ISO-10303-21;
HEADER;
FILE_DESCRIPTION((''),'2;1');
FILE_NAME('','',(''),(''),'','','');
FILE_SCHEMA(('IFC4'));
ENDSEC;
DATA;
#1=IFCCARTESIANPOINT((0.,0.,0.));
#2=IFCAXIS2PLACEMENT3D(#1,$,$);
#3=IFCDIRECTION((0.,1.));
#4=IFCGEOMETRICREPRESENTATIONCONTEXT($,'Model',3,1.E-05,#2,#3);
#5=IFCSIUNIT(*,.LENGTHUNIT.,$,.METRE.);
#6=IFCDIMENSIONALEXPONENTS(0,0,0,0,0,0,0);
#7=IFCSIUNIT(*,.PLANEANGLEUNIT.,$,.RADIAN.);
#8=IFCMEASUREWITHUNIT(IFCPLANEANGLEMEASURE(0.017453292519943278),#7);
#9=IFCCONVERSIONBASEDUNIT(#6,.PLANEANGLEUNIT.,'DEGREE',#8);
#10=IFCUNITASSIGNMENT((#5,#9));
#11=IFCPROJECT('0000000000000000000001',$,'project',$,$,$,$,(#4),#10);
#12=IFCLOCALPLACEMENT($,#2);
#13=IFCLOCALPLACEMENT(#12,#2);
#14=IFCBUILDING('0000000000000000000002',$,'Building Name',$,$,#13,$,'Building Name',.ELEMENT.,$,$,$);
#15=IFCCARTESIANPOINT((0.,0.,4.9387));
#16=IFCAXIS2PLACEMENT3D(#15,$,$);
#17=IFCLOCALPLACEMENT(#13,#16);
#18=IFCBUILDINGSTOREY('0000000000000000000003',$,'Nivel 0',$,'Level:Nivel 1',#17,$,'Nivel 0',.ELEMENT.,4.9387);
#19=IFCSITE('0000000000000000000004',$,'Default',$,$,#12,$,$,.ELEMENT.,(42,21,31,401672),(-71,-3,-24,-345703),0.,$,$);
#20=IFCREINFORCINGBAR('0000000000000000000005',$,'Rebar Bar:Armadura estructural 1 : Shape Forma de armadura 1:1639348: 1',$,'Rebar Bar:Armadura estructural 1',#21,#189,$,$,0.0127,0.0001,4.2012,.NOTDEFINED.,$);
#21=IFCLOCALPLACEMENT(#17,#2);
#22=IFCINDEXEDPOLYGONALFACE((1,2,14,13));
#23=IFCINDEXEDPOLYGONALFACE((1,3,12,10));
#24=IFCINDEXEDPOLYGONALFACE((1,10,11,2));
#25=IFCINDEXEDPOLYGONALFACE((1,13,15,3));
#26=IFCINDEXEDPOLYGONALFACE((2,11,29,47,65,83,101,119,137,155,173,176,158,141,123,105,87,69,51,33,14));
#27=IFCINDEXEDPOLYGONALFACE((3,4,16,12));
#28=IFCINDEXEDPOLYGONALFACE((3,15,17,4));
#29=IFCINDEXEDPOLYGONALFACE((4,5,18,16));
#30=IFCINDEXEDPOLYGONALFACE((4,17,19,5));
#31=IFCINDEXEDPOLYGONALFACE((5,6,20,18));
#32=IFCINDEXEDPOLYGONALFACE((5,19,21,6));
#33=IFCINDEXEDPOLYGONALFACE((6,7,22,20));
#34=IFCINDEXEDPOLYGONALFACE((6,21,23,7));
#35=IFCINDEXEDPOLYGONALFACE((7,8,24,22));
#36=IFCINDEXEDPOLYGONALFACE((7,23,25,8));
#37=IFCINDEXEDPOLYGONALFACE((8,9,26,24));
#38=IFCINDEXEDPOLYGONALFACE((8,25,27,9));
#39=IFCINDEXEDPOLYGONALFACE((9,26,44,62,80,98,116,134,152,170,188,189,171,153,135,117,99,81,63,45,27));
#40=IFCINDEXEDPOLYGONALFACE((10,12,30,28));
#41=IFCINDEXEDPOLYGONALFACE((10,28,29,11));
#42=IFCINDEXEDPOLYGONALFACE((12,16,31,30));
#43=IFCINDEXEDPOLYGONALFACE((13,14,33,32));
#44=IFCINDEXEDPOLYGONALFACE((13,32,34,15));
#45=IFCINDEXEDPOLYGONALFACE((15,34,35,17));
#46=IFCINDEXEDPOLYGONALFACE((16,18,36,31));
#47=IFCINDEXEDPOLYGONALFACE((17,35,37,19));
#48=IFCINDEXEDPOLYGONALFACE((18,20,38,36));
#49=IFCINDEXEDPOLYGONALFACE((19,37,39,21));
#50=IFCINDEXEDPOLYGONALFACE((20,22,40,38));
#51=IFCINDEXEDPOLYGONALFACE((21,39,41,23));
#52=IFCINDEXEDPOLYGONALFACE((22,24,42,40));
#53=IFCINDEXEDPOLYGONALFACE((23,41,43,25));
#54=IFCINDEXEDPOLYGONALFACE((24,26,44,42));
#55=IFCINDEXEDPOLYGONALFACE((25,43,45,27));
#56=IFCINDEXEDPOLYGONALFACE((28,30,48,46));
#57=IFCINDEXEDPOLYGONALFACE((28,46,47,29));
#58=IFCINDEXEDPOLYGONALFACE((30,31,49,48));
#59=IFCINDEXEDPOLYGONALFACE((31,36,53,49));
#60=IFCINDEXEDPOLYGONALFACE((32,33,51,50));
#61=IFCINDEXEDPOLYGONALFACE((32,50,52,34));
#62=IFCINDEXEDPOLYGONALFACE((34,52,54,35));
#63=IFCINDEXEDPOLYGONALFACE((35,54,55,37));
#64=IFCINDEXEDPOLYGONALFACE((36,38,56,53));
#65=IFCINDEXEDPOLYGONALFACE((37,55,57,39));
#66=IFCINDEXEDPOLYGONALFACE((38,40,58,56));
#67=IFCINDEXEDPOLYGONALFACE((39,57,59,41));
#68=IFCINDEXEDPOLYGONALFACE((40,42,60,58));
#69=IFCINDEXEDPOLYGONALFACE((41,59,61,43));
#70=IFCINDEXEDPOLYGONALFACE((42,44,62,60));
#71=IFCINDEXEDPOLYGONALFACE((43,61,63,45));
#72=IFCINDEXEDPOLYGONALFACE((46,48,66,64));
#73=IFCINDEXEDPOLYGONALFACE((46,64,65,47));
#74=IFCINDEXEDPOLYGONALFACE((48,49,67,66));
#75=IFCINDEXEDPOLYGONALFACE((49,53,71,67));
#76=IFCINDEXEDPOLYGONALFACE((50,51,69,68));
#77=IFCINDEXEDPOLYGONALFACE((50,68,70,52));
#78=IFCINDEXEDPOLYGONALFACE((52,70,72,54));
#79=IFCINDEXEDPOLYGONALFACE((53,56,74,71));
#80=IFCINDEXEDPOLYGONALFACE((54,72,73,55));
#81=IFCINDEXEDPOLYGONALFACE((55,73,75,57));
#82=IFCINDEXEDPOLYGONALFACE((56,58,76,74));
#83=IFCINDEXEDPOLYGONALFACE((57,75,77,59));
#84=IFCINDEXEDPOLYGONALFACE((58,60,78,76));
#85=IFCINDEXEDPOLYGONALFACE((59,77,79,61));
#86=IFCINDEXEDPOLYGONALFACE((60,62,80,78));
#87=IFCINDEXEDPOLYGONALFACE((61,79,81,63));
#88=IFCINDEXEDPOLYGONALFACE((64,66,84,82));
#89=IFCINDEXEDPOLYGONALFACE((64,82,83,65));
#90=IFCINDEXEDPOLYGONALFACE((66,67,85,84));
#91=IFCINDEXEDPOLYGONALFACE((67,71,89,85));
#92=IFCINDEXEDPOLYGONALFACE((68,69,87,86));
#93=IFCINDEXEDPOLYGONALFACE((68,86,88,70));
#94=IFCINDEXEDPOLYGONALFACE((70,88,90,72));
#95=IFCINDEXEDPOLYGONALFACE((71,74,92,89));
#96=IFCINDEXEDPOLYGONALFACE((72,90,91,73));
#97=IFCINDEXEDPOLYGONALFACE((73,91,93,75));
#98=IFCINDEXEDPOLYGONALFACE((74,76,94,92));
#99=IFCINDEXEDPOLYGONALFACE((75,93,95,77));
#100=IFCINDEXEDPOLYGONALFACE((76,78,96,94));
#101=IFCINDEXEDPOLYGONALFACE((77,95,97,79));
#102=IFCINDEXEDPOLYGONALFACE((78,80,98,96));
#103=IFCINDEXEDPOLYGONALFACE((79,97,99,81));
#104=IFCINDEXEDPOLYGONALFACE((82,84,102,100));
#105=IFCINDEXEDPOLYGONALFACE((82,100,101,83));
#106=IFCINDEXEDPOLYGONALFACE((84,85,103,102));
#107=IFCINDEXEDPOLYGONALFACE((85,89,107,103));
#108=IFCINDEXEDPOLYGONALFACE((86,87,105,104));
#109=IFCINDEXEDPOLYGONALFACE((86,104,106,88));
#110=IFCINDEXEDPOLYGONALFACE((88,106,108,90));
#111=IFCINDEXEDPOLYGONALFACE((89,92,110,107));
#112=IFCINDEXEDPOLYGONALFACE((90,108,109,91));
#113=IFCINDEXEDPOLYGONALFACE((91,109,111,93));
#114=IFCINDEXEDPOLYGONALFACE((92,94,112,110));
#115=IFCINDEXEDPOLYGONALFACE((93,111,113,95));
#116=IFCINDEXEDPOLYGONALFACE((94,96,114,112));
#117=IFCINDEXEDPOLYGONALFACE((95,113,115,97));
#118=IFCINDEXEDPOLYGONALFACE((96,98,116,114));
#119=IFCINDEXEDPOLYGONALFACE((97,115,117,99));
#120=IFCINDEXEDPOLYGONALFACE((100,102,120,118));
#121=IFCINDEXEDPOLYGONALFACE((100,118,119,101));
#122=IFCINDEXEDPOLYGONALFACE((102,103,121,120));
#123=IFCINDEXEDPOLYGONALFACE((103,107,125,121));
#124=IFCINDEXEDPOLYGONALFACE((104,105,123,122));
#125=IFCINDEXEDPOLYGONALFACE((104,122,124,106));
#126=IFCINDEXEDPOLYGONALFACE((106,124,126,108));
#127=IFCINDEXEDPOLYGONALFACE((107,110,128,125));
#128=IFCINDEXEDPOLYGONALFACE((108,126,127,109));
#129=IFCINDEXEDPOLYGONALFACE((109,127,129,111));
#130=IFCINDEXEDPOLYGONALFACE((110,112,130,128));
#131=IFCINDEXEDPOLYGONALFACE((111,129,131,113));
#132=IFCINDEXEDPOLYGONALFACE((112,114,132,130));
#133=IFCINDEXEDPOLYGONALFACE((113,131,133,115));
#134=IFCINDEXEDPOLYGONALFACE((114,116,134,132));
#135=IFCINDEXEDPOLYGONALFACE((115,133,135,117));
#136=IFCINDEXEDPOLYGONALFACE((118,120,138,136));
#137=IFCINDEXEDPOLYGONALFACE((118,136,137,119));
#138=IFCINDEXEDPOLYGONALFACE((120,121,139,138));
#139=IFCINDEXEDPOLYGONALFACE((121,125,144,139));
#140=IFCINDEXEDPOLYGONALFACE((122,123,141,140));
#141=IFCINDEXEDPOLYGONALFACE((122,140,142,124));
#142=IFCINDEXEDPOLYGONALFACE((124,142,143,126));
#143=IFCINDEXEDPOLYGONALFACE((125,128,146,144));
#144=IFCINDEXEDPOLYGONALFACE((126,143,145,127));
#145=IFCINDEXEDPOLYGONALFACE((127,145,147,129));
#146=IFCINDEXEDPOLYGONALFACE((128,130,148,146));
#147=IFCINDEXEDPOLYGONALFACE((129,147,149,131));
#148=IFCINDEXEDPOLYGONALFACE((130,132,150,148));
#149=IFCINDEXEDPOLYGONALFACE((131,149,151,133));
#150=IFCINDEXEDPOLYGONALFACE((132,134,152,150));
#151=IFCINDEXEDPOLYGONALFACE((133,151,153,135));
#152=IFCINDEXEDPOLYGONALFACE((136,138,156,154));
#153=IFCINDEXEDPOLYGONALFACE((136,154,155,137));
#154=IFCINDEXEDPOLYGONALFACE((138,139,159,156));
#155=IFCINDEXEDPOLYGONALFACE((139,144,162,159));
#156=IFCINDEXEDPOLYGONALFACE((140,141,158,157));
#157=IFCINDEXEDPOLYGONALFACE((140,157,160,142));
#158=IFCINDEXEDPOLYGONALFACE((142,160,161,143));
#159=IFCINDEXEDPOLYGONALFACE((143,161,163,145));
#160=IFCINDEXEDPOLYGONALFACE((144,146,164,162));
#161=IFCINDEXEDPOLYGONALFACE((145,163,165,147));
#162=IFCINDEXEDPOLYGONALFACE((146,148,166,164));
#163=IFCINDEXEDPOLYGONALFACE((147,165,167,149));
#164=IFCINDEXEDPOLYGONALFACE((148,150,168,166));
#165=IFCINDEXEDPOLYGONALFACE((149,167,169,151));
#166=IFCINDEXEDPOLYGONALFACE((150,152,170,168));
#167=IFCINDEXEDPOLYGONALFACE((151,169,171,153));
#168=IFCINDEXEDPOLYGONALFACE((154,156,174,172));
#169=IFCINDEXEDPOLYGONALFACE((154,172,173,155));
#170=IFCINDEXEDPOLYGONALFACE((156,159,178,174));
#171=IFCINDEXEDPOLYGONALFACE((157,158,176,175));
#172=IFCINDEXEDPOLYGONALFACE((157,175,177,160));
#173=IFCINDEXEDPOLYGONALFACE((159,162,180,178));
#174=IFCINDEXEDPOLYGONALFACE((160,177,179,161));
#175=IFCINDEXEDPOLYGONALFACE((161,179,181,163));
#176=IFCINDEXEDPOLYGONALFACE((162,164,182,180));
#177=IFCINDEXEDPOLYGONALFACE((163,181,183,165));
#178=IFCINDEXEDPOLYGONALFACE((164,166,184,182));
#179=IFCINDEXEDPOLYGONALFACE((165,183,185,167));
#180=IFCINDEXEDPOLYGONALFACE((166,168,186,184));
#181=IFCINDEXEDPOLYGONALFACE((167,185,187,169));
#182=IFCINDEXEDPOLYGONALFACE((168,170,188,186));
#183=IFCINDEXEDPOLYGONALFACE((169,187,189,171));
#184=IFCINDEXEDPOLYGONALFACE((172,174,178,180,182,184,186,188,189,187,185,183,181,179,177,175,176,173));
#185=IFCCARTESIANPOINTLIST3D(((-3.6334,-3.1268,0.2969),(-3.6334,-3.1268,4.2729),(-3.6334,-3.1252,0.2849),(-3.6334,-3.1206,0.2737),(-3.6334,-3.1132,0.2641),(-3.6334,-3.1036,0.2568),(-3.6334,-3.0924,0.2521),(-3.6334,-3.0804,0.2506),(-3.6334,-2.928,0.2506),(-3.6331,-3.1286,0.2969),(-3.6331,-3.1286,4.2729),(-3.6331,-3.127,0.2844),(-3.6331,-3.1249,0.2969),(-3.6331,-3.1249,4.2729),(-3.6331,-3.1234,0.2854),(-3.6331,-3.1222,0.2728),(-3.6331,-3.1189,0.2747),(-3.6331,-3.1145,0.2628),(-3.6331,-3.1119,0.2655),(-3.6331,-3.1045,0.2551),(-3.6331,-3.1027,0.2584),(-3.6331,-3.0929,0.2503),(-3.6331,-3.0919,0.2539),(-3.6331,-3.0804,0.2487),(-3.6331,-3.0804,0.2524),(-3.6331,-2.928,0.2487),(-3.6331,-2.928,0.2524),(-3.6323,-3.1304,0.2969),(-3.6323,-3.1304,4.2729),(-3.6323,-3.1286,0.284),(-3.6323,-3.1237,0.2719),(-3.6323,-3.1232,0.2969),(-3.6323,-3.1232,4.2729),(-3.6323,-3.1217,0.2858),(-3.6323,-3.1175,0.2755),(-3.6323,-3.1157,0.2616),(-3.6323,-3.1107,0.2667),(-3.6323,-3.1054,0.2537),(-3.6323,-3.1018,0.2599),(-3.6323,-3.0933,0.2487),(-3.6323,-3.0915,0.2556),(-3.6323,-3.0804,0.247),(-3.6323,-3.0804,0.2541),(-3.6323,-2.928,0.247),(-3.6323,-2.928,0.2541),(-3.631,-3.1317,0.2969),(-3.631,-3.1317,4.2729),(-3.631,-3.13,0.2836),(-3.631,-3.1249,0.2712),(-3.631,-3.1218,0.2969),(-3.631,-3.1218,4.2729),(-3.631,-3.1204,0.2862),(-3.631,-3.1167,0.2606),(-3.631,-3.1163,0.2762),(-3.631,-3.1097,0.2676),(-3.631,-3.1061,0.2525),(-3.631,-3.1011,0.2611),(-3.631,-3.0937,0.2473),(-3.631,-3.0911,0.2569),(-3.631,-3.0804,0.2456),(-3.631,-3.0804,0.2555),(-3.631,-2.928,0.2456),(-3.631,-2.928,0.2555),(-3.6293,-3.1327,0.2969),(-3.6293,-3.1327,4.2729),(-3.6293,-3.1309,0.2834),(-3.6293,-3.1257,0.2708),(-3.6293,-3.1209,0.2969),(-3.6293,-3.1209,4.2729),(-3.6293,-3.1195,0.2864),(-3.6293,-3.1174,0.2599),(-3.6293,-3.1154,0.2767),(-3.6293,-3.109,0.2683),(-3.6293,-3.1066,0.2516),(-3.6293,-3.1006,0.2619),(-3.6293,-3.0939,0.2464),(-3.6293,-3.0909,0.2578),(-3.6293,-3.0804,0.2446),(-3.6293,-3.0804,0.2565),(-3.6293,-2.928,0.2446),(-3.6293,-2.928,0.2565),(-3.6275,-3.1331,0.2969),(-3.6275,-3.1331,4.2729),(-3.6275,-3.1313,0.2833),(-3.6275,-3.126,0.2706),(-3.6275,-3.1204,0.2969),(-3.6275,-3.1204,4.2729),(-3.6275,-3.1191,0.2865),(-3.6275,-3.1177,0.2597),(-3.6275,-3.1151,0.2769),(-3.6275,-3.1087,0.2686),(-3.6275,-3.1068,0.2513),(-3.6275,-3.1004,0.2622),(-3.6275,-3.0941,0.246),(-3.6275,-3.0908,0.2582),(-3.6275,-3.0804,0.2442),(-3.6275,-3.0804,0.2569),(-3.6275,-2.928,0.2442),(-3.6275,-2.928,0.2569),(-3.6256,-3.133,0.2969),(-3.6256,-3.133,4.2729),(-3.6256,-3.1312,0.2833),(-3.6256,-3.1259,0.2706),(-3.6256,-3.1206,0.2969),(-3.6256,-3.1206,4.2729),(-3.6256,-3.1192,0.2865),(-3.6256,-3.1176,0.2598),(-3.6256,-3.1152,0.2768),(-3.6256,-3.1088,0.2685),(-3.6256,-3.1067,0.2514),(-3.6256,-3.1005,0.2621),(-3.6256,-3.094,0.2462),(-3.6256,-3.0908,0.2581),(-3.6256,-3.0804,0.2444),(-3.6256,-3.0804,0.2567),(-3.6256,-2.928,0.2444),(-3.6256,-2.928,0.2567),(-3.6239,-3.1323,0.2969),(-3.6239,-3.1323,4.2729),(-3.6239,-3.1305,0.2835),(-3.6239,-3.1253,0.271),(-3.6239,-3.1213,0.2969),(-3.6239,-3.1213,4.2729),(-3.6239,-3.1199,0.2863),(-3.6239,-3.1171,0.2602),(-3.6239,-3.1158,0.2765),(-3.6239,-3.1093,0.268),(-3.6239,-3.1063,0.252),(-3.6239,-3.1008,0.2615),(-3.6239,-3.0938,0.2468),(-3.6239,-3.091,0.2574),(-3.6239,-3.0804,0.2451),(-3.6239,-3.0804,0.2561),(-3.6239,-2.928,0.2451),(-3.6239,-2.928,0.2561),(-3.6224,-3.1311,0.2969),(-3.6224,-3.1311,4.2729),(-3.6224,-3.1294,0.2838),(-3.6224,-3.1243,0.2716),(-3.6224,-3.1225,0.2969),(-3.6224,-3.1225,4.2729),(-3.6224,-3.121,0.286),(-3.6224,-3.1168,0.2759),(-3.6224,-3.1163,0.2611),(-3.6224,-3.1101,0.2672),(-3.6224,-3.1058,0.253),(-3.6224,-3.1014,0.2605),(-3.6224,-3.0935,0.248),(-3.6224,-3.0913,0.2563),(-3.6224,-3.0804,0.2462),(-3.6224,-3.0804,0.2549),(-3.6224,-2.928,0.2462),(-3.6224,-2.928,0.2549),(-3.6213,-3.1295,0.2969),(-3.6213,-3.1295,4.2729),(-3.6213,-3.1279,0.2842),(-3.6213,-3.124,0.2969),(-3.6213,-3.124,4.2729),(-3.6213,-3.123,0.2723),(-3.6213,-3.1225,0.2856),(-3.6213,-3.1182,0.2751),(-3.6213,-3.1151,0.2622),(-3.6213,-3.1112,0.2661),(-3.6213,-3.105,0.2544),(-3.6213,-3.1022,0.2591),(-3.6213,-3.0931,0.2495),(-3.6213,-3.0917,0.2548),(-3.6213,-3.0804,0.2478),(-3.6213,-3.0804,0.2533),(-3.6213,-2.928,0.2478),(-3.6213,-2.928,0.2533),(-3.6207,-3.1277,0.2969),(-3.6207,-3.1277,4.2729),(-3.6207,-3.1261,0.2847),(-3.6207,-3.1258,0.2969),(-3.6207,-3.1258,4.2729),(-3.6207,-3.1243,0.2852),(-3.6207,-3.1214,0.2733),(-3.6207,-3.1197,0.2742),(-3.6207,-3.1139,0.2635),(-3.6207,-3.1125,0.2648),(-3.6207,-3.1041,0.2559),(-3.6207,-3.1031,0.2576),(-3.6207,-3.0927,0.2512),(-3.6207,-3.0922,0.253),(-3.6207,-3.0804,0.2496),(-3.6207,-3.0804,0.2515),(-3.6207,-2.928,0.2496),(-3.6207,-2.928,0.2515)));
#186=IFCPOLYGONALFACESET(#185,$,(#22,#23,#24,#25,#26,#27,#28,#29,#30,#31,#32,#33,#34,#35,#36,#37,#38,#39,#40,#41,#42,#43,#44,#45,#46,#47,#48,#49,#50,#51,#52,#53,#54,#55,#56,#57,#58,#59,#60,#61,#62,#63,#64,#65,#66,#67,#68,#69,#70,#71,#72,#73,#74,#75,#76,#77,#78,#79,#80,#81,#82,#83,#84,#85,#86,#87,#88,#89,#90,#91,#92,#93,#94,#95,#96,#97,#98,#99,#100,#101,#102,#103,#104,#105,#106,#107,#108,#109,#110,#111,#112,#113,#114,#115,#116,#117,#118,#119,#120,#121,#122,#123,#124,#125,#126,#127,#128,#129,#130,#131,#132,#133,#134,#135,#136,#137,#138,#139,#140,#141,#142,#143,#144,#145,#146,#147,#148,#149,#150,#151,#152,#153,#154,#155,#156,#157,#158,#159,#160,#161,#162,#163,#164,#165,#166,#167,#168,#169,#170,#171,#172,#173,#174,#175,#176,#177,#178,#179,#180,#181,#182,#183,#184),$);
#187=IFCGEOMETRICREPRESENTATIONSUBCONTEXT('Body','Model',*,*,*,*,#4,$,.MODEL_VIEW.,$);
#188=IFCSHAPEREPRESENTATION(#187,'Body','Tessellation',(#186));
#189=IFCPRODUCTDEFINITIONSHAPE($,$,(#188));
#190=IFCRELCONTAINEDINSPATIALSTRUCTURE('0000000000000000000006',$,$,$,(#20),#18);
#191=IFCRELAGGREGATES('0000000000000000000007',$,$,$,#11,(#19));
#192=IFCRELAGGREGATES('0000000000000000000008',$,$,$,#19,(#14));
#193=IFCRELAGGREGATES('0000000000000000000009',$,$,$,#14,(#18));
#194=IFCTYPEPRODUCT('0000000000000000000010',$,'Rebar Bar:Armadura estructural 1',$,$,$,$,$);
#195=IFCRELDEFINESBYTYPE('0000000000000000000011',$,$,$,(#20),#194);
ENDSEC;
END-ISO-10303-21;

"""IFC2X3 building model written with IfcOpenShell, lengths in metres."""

from ifc_helpers import new_model, entity, si_unit, converted_unit, direction, frame, origin, place, context, subcontext, project, spatial, type_object, element, save


model = new_model("IFC2X3")

# Units and contexts
model_context = context("Model", 3, precision=1e-05, world=origin(), true_north=direction((0.0, 1.0)))
body_context = subcontext(model_context, "Body", "Model", "MODEL_VIEW")
ifc_project = project(units=[si_unit("LENGTHUNIT", "METRE"), converted_unit("PLANEANGLEUNIT", "DEGREE", entity("IfcPlaneAngleMeasure", 0.017453292519943278), si_unit("PLANEANGLEUNIT", "RADIAN"), dimensions=[0, 0, 0, 0, 0, 0, 0])], contexts=[model_context])

# Site, building, storey
site_placement = place(None, origin())
site = spatial("IfcSite", under=ifc_project, at=site_placement, Name="Default", CompositionType="ELEMENT", RefLatitude=(42, 21, 31, 401672), RefLongitude=(-71, -3, -24, -345703), RefElevation=0.0)
building_placement = place(site_placement, origin())
building = spatial("IfcBuilding", under=site, at=building_placement, Name="Building Name", LongName="Building Name", CompositionType="ELEMENT")
storey_placement = place(building_placement, frame((0.0, 0.0, 4.9387)))
storey = spatial("IfcBuildingStorey", under=building, at=storey_placement, Name="Nivel 0", ObjectType="Level:Nivel 1", LongName="Nivel 0", CompositionType="ELEMENT", Elevation=4.9387)

# Reinforcing bar
type_product = type_object("IfcTypeProduct", Name="Rebar Bar:Armadura estructural 1")
reinforcing_bar_1_placement = place(storey_placement, origin())
element("IfcReinforcingBar", 1, at=reinforcing_bar_1_placement, inside=storey, type_object=type_product, Name="Rebar Bar:Armadura estructural 1 : Shape Forma de armadura 1:1639348: 1", ObjectType="Rebar Bar:Armadura estructural 1", BarLength=4.2012, BarRole="NOTDEFINED", CrossSectionArea=0.0001, NominalDiameter=0.0127, context=body_context, shape_type="AdvancedSweptSolid", body=[
    entity("IfcSweptDiskSolid", entity("IfcCompositeCurve", [entity("IfcCompositeCurveSegment", "CONTINUOUS", True, entity("IfcPolyline", [entity("IfcCartesianPoint", [-3.627, -2.928, 0.2506]), entity("IfcCartesianPoint", [-3.627, -3.0804, 0.2506])])), entity("IfcCompositeCurveSegment", "CONTINUOUS", True, entity("IfcTrimmedCurve", entity("IfcCircle", entity("IfcAxis2Placement3D", entity("IfcCartesianPoint", [-3.627, -3.0804, 0.2969]), entity("IfcDirection", [-1.0, 0.0, 0.0]), entity("IfcDirection", [0.0, -1.0, 0.0])), 0.0464), [entity("IfcParameterValue", 270.0)], [entity("IfcParameterValue", 360.0)], True, "PARAMETER")), entity("IfcCompositeCurveSegment", "CONTINUOUS", True, entity("IfcPolyline", [entity("IfcCartesianPoint", [-3.627, -3.1268, 0.2969]), entity("IfcCartesianPoint", [-3.627, -3.1268, 4.2729])]))], False), 0.0063, None, 0.0, 92.0),
])

save(model, "model.ifc")
